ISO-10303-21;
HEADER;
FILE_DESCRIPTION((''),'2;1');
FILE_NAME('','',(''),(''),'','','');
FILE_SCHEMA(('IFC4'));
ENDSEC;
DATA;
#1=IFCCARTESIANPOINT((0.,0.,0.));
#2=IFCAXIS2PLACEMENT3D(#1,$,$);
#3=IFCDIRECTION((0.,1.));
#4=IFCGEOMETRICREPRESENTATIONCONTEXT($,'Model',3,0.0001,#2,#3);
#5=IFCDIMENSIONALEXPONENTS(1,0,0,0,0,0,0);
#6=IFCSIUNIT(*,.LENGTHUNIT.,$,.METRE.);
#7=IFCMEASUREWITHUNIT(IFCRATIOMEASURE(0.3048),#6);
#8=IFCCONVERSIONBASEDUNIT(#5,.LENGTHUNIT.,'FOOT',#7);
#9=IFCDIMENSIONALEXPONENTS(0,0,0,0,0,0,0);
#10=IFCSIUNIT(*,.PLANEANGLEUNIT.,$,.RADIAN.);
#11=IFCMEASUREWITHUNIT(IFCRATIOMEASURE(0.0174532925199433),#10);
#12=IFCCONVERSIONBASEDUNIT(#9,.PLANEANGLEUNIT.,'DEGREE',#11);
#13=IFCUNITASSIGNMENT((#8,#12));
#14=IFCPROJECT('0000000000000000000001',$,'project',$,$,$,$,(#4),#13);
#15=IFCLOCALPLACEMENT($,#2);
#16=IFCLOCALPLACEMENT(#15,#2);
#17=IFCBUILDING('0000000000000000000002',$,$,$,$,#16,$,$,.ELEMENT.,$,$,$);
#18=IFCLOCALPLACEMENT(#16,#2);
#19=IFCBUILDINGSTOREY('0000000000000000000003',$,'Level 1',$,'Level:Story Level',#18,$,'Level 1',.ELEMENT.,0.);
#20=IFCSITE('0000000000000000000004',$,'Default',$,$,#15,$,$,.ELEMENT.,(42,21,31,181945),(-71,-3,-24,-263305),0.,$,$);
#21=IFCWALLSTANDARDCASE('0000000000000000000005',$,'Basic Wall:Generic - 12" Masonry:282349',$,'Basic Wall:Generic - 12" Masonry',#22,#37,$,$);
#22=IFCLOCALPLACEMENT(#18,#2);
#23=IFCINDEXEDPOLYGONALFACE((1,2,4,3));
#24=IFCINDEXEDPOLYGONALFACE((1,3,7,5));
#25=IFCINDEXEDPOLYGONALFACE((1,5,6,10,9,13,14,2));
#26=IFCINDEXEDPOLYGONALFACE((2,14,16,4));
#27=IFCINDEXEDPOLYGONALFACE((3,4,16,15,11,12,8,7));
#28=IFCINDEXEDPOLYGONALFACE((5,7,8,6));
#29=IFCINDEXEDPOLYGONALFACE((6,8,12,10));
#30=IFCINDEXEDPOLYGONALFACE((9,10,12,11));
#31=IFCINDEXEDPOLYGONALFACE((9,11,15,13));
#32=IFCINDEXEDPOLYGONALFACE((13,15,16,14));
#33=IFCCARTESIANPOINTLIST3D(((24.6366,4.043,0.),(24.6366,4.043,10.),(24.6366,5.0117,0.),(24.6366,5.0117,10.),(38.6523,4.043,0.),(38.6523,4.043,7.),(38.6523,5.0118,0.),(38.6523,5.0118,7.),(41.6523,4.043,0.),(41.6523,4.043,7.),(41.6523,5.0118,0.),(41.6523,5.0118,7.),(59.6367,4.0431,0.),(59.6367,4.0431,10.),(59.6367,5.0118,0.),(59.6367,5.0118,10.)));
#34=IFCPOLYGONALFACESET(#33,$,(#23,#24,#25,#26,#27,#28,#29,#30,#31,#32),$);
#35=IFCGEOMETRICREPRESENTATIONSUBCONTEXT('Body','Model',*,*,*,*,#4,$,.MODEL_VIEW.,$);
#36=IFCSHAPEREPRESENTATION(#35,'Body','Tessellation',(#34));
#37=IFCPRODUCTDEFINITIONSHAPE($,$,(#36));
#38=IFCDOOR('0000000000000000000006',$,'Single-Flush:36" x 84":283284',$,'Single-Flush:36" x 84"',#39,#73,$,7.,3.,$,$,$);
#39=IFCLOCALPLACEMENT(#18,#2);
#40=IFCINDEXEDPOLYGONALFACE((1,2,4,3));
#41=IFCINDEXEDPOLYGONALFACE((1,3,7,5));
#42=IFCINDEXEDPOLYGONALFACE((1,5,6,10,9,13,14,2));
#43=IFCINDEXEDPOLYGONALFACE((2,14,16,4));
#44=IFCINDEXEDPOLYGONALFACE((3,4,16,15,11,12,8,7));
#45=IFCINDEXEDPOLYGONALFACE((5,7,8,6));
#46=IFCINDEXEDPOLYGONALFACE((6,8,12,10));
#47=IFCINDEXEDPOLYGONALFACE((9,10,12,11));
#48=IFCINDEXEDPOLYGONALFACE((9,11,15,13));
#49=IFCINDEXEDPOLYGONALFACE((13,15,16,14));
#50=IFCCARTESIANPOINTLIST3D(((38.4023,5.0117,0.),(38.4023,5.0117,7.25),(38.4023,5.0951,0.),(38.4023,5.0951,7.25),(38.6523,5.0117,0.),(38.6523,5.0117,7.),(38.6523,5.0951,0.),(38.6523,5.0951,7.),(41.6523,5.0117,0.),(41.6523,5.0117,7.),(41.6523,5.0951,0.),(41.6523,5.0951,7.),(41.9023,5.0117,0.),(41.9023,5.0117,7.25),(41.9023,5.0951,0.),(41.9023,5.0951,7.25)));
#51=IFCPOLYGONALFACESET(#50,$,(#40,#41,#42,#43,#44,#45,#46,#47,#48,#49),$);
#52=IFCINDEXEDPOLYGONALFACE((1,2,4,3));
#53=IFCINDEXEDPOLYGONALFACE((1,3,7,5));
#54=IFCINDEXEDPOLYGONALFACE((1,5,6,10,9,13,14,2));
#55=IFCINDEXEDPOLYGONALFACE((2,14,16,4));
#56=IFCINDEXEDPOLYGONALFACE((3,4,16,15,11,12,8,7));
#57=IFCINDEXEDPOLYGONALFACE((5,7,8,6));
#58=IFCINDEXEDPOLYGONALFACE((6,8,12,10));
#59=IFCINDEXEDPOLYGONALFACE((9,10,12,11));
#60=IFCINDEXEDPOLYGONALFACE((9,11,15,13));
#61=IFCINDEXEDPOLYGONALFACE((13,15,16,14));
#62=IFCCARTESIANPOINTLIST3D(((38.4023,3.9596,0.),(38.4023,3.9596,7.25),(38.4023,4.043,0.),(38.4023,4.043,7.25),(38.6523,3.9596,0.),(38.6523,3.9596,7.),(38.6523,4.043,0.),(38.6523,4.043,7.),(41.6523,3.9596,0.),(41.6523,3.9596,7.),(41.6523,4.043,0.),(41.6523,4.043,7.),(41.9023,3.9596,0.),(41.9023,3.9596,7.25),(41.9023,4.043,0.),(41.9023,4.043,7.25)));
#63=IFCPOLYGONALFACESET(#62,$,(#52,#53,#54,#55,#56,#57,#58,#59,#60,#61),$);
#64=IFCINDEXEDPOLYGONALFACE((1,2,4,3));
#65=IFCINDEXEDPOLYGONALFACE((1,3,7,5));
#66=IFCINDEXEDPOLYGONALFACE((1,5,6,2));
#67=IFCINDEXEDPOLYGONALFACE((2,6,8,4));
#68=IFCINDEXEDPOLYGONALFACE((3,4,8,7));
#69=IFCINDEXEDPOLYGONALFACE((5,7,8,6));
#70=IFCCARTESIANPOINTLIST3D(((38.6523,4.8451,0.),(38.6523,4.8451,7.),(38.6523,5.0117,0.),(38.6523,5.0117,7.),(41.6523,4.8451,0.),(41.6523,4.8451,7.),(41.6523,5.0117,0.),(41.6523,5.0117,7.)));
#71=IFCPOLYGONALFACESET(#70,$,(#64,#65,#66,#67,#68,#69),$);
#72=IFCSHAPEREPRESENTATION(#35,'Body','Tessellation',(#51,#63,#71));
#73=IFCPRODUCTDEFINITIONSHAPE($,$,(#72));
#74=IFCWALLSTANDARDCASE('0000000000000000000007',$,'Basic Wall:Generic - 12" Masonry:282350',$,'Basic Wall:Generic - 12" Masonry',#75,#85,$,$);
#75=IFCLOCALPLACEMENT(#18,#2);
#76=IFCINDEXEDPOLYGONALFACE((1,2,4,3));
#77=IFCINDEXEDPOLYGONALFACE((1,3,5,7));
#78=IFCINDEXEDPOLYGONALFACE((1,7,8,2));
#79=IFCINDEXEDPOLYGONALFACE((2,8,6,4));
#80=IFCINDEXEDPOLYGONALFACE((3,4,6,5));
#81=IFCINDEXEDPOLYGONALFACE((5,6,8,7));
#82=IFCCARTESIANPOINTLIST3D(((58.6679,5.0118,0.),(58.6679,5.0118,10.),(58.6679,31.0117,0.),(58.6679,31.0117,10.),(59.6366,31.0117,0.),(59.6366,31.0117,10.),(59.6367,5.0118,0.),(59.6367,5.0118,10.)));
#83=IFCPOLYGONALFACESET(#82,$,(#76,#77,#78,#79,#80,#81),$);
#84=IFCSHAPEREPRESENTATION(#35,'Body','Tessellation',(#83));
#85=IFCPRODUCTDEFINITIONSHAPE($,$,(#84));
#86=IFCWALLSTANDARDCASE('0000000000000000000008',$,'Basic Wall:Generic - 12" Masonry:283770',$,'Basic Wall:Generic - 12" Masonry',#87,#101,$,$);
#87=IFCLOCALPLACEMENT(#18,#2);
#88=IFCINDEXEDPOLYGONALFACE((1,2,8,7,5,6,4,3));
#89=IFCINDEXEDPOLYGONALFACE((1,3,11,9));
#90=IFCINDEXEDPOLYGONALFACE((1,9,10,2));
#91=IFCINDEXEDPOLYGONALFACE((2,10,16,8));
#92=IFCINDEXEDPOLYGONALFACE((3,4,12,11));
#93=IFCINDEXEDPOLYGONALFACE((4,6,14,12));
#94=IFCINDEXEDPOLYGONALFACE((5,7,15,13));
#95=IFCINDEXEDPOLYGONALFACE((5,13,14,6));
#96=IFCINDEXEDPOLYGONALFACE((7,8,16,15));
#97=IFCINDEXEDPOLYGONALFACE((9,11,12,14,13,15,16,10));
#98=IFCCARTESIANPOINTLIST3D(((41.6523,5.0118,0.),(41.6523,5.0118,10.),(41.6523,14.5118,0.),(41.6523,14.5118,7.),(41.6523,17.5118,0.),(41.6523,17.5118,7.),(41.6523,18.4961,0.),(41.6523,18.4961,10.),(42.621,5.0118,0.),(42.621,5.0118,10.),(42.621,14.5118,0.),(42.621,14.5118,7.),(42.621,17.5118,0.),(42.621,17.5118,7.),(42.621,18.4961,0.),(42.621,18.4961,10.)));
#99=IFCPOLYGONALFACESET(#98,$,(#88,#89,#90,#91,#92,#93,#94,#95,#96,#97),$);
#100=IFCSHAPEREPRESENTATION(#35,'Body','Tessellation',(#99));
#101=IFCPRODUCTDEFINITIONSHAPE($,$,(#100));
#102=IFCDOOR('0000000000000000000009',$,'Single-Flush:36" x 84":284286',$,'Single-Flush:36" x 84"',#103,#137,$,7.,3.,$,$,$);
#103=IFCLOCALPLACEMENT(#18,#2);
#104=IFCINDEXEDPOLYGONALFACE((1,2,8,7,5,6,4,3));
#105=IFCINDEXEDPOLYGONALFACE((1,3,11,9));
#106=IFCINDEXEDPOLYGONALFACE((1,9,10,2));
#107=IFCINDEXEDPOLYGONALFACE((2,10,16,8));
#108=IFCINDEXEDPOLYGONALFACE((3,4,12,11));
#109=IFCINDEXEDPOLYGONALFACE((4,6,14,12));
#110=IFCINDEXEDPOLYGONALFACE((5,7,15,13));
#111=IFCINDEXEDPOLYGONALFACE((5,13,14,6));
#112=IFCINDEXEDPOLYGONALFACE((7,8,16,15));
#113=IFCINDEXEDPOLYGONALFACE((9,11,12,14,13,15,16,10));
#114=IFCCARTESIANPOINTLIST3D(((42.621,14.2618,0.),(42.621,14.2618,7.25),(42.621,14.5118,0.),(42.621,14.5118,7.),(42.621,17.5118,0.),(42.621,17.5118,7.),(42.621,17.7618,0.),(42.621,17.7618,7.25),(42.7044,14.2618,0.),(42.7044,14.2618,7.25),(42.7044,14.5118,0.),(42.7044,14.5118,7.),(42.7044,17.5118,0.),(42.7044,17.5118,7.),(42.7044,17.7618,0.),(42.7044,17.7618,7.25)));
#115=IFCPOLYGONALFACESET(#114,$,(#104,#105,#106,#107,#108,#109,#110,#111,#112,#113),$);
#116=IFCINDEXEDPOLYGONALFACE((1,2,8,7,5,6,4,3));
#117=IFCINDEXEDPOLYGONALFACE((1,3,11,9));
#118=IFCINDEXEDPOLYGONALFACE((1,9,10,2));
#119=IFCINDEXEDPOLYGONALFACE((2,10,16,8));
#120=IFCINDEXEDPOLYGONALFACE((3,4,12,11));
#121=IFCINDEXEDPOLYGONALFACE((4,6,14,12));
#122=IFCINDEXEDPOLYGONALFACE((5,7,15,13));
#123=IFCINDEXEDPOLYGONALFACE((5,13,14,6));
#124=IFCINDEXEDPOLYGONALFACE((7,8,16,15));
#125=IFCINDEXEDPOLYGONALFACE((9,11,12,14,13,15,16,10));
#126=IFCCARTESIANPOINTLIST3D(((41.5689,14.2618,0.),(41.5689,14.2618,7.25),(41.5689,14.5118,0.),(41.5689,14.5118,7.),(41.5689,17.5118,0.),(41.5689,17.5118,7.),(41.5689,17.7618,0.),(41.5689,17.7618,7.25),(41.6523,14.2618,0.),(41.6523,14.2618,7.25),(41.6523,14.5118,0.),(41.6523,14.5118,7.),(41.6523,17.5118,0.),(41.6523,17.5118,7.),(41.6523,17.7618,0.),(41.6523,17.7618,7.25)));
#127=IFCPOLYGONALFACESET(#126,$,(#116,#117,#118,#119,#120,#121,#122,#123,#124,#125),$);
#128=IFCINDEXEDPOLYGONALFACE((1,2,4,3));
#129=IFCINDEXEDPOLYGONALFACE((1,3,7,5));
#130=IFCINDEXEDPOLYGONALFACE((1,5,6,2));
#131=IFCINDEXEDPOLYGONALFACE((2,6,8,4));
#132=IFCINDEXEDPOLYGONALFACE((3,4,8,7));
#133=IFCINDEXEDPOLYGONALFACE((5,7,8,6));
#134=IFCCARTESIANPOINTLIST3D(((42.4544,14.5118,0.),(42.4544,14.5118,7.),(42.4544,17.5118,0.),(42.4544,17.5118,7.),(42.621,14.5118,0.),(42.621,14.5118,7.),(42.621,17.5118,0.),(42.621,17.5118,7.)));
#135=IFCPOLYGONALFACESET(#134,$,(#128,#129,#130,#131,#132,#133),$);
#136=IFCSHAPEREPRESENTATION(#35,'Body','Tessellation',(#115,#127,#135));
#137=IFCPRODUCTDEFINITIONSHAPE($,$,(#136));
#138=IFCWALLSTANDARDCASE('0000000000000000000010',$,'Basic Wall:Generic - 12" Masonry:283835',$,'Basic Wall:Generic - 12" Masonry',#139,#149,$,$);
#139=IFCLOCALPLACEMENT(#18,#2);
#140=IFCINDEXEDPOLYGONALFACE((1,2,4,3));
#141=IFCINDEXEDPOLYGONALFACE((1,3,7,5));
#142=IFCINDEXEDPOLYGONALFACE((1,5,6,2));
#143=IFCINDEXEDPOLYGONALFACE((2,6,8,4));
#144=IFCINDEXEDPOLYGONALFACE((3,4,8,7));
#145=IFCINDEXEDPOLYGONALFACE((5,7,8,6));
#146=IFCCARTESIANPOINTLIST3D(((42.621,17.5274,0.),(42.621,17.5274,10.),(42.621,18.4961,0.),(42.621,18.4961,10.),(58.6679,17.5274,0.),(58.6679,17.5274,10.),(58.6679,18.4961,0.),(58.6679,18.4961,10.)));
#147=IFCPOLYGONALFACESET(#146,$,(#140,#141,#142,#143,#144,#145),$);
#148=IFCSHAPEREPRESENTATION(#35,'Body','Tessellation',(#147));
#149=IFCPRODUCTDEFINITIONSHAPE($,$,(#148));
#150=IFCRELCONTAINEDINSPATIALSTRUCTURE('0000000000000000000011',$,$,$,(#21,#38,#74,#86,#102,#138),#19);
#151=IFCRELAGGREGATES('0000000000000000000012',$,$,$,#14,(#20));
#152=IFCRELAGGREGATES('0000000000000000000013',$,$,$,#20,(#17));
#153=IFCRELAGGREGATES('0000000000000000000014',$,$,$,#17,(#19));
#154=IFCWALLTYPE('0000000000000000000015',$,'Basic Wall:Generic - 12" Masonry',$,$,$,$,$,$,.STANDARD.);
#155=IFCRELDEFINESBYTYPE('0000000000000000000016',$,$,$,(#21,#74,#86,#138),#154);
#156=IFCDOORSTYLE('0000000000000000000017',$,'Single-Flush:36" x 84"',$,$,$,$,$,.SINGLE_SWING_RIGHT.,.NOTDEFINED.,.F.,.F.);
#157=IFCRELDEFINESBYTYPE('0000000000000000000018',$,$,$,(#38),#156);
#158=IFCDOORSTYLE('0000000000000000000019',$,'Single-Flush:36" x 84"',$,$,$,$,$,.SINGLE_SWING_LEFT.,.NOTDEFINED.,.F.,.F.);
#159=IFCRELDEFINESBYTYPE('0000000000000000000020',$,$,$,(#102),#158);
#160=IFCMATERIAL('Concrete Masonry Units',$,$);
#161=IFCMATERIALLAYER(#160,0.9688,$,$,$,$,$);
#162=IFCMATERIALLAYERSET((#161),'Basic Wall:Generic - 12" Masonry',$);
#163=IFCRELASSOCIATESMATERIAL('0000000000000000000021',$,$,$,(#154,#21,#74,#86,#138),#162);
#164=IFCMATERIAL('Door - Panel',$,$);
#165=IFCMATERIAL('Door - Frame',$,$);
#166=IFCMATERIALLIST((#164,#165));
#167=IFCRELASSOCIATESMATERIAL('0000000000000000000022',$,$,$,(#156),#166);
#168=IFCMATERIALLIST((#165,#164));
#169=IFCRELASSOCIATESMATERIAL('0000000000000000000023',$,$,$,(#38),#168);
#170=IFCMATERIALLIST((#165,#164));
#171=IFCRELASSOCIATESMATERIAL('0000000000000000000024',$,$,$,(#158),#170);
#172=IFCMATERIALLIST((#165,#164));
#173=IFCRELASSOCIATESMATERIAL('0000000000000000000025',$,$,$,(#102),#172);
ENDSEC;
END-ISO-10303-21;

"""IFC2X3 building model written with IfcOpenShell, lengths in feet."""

from ifc_helpers import new_model, entity, si_unit, converted_unit, direction, frame, frame_2d, origin, place, context, subcontext, project, spatial, polyline, rectangle, outline, extrude, source, transform, mapped, material, material_list, layer, layer_set, layer_usage, type_object, type_shapes, element, fill, save


model = new_model("IFC2X3")

# Units and contexts
model_context = context("Model", 3, precision=0.0001, world=origin(), true_north=direction((0.0, 1.0)))
body_context = subcontext(model_context, "Body", "Model", "MODEL_VIEW")
ifc_project = project(units=[converted_unit("LENGTHUNIT", "FOOT", entity("IfcRatioMeasure", 0.3048), si_unit("LENGTHUNIT", "METRE"), dimensions=[1, 0, 0, 0, 0, 0, 0]), converted_unit("PLANEANGLEUNIT", "DEGREE", entity("IfcRatioMeasure", 0.0174532925199433), si_unit("PLANEANGLEUNIT", "RADIAN"), dimensions=[0, 0, 0, 0, 0, 0, 0])], contexts=[model_context])

# Site, building, storey
site_placement = place(None, origin())
site = spatial("IfcSite", under=ifc_project, at=site_placement, Name="Default", CompositionType="ELEMENT", RefLatitude=(42, 21, 31, 181945), RefLongitude=(-71, -3, -24, -263305), RefElevation=0.0)
building_placement = place(site_placement, origin())
building = spatial("IfcBuilding", under=site, at=building_placement, CompositionType="ELEMENT")
storey_placement = place(building_placement, origin())
storey = spatial("IfcBuildingStorey", under=building, at=storey_placement, Name="Level 1", ObjectType="Level:Story Level", LongName="Level 1", CompositionType="ELEMENT", Elevation=0.0)

# Shared definitions
ifc_material_1 = material(Name="Concrete Masonry Units")
ifc_layer_1 = layer(ifc_material_1, 0.9688)
ifc_layer_set_1 = layer_set([ifc_layer_1], Name="Basic Wall:Generic - 12\" Masonry")
wall_type = type_object("IfcWallType", Name="Basic Wall:Generic - 12\" Masonry", PredefinedType="STANDARD", material=ifc_layer_set_1)

# Wall, opening, door
ifc_layer_usage_1 = layer_usage(ifc_layer_set_1, "AXIS2", "NEGATIVE", 0.4844)
wall_1_placement = place(storey_placement, frame((59.6367, 4.5274, 0.0), z_axis=(0.0, 0.0, 1.0), x_axis=(-1.0, -0.000002, 0.0)))
wall_1 = element("IfcWallStandardCase", 1, at=wall_1_placement, inside=storey, type_object=wall_type, material=ifc_layer_usage_1, Name="Basic Wall:Generic - 12\" Masonry:282349", ObjectType="Basic Wall:Generic - 12\" Masonry", context=body_context, shape_type="SweptSolid", body=[
    extrude(rectangle(XDim=35.0, YDim=0.9688, at=frame_2d((17.5, 0.0), x_axis=(-1.0, 0.0))), origin(), (0.0, 0.0, 1.0), 10.0),
])
opening_1_placement = place(wall_1_placement, frame((20.9844, 0.4844, 0.0)))
opening_1 = element("IfcOpeningElement", 2, at=opening_1_placement, cuts=wall_1, ObjectType="Opening", context=body_context, shape_type="SweptSolid", body=[
    extrude(rectangle(XDim=3.0, YDim=7.0, at=frame_2d((3.5, 1.5), x_axis=(0.0, 1.0))), frame((0.0, 0.0, 0.0), z_axis=(0.000002, -1.0, 0.0), x_axis=(0.0, 0.0, 1.0)), (0.0, 0.0, 1.0), 0.9688),
])
ifc_material_2 = material(Name="Door - Frame")
ifc_material_3 = material(Name="Door - Panel")
ifc_material_list_1 = material_list([ifc_material_2, ifc_material_3])
ifc_material_list_2 = material_list([ifc_material_3, ifc_material_2])
door_style_1 = type_object("IfcDoorStyle", Name="Single-Flush:36\" x 84\"", ConstructionType="NOTDEFINED", OperationType="SINGLE_SWING_RIGHT", ParameterTakesPrecedence=False, Sizeable=False, material=ifc_material_list_2)
shared_shape_1 = source(origin(), body_context, "Body", "SweptSolid", [
    extrude(outline(polyline([(-1.75, -3.6875), (1.75, -3.6875), (1.75, 3.5625), (1.5, 3.5625), (1.5, -3.4375), (-1.5, -3.4375), (-1.5, 3.5625), (-1.75, 3.5625), (-1.75, -3.6875)])), frame((1.5, 0.9688, 3.5625), z_axis=(0.0, 1.0, 0.0), x_axis=(1.0, 0.0, 0.0)), (0.0, 0.0, 1.0), 0.0833),
    extrude(outline(polyline([(-3.6875, -1.75), (3.5625, -1.75), (3.5625, -1.5), (-3.4375, -1.5), (-3.4375, 1.5), (3.5625, 1.5), (3.5625, 1.75), (-3.6875, 1.75), (-3.6875, -1.75)])), frame((1.5, -0.0833, 3.5625), z_axis=(0.0, 1.0, 0.0), x_axis=(0.0, 0.0, -1.0)), (0.0, 0.0, 1.0), 0.0833),
    extrude(rectangle(XDim=0.1667, YDim=3.0, at=frame_2d((0.0, 0.0), x_axis=(1.0, 0.0))), frame((1.5, 0.8854, 0.0), z_axis=(0.0, 0.0, 1.0), x_axis=(0.0, 1.0, 0.0)), (0.0, 0.0, 1.0), 7.0),
])
type_shapes(door_style_1, [shared_shape_1])
door_1_placement = place(opening_1_placement, frame((0.0, 0.0, 0.0), z_axis=(0.0, 0.0, 1.0), x_axis=(-1.0, 0.0, 0.0)))
door_1 = element("IfcDoor", 3, at=door_1_placement, inside=storey, type_object=door_style_1, material=ifc_material_list_1, Name="Single-Flush:36\" x 84\":283284", ObjectType="Single-Flush:36\" x 84\"", OverallHeight=7.0, OverallWidth=3.0, context=body_context, shape_type="MappedRepresentation", body=[
    mapped(shared_shape_1, transform((0.0, 0.0, 0.0), scale=1.0)),
])
fill(opening_1, door_1)

# Wall
ifc_layer_usage_2 = layer_usage(ifc_layer_set_1, "AXIS2", "NEGATIVE", 0.4844)
wall_2_placement = place(storey_placement, frame((59.1523, 31.0117, 0.0), z_axis=(0.0, 0.0, 1.0), x_axis=(0.000002, -1.0, 0.0)))
element("IfcWallStandardCase", 4, at=wall_2_placement, inside=storey, type_object=wall_type, material=ifc_layer_usage_2, Name="Basic Wall:Generic - 12\" Masonry:282350", ObjectType="Basic Wall:Generic - 12\" Masonry", context=body_context, shape_type="SweptSolid", body=[
    extrude(rectangle(XDim=25.9999, YDim=0.9688, at=frame_2d((13.0, 0.0), x_axis=(-1.0, 0.0))), origin(), (0.0, 0.0, 1.0), 10.0),
])

# Wall, opening, door
ifc_layer_usage_3 = layer_usage(ifc_layer_set_1, "AXIS2", "NEGATIVE", 0.4844)
wall_3_placement = place(storey_placement, frame((42.1366, 5.0118, 0.0), z_axis=(0.0, 0.0, 1.0), x_axis=(0.0, 1.0, 0.0)))
wall_3 = element("IfcWallStandardCase", 5, at=wall_3_placement, inside=storey, type_object=wall_type, material=ifc_layer_usage_3, Name="Basic Wall:Generic - 12\" Masonry:283770", ObjectType="Basic Wall:Generic - 12\" Masonry", context=body_context, shape_type="SweptSolid", body=[
    extrude(rectangle(XDim=13.4844, YDim=0.9688, at=frame_2d((6.7422, 0.0), x_axis=(-1.0, 0.0))), origin(), (0.0, 0.0, 1.0), 10.0),
])
opening_2_placement = place(wall_3_placement, frame((12.5, 0.4844, 0.0)))
opening_2 = element("IfcOpeningElement", 6, at=opening_2_placement, cuts=wall_3, ObjectType="Opening", context=body_context, shape_type="SweptSolid", body=[
    extrude(rectangle(XDim=3.0, YDim=7.0, at=frame_2d((3.5, 1.5), x_axis=(0.0, -1.0))), frame((0.0, 0.0, 0.0), z_axis=(0.0, -1.0, 0.0), x_axis=(0.0, 0.0, 1.0)), (0.0, 0.0, 1.0), 0.9688),
])
ifc_material_list_3 = material_list([ifc_material_2, ifc_material_3])
ifc_material_list_4 = material_list([ifc_material_2, ifc_material_3])
door_style_2 = type_object("IfcDoorStyle", Name="Single-Flush:36\" x 84\"", ConstructionType="NOTDEFINED", OperationType="SINGLE_SWING_LEFT", ParameterTakesPrecedence=False, Sizeable=False, material=ifc_material_list_4)
shared_shape_2 = source(origin(), body_context, "Body", "SweptSolid", [
    extrude(outline(polyline([(-1.75, -3.6875), (1.75, -3.6875), (1.75, 3.5625), (1.5, 3.5625), (1.5, -3.4375), (-1.5, -3.4375), (-1.5, 3.5625), (-1.75, 3.5625), (-1.75, -3.6875)])), frame((1.5, 1.0521, 3.5625), z_axis=(0.0, -1.0, 0.0), x_axis=(-1.0, 0.0, 0.0)), (0.0, 0.0, 1.0), 0.0833),
    extrude(outline(polyline([(-3.6875, -1.75), (3.5625, -1.75), (3.5625, -1.5), (-3.4375, -1.5), (-3.4375, 1.5), (3.5625, 1.5), (3.5625, 1.75), (-3.6875, 1.75), (-3.6875, -1.75)])), frame((1.5, 0.0, 3.5625), z_axis=(0.0, -1.0, 0.0), x_axis=(0.0, 0.0, -1.0)), (0.0, 0.0, 1.0), 0.0833),
    extrude(rectangle(XDim=3.0, YDim=0.1667, at=frame_2d((0.0, 0.0), x_axis=(1.0, 0.0))), frame((1.5, 0.8854, 0.0)), (0.0, 0.0, 1.0), 7.0),
])
type_shapes(door_style_2, [shared_shape_2])
door_2_placement = place(opening_2_placement, frame((0.0, 0.0, 0.0), z_axis=(0.0, 0.0, 1.0), x_axis=(-1.0, 0.0, 0.0)))
door_2 = element("IfcDoor", 7, at=door_2_placement, inside=storey, type_object=door_style_2, material=ifc_material_list_3, Name="Single-Flush:36\" x 84\":284286", ObjectType="Single-Flush:36\" x 84\"", OverallHeight=7.0, OverallWidth=3.0, context=body_context, shape_type="MappedRepresentation", body=[
    mapped(shared_shape_2, transform((0.0, 0.0, 0.0), scale=1.0)),
])
fill(opening_2, door_2)

# Wall
ifc_layer_usage_4 = layer_usage(ifc_layer_set_1, "AXIS2", "NEGATIVE", 0.4844)
wall_4_placement = place(storey_placement, frame((42.621, 18.0118, 0.0)))
element("IfcWallStandardCase", 8, at=wall_4_placement, inside=storey, type_object=wall_type, material=ifc_layer_usage_4, Name="Basic Wall:Generic - 12\" Masonry:283835", ObjectType="Basic Wall:Generic - 12\" Masonry", context=body_context, shape_type="SweptSolid", body=[
    extrude(rectangle(XDim=16.0469, YDim=0.9688, at=frame_2d((8.0234, 0.0), x_axis=(-1.0, 0.0))), origin(), (0.0, 0.0, 1.0), 10.0),
])

save(model, "model.ifc")
